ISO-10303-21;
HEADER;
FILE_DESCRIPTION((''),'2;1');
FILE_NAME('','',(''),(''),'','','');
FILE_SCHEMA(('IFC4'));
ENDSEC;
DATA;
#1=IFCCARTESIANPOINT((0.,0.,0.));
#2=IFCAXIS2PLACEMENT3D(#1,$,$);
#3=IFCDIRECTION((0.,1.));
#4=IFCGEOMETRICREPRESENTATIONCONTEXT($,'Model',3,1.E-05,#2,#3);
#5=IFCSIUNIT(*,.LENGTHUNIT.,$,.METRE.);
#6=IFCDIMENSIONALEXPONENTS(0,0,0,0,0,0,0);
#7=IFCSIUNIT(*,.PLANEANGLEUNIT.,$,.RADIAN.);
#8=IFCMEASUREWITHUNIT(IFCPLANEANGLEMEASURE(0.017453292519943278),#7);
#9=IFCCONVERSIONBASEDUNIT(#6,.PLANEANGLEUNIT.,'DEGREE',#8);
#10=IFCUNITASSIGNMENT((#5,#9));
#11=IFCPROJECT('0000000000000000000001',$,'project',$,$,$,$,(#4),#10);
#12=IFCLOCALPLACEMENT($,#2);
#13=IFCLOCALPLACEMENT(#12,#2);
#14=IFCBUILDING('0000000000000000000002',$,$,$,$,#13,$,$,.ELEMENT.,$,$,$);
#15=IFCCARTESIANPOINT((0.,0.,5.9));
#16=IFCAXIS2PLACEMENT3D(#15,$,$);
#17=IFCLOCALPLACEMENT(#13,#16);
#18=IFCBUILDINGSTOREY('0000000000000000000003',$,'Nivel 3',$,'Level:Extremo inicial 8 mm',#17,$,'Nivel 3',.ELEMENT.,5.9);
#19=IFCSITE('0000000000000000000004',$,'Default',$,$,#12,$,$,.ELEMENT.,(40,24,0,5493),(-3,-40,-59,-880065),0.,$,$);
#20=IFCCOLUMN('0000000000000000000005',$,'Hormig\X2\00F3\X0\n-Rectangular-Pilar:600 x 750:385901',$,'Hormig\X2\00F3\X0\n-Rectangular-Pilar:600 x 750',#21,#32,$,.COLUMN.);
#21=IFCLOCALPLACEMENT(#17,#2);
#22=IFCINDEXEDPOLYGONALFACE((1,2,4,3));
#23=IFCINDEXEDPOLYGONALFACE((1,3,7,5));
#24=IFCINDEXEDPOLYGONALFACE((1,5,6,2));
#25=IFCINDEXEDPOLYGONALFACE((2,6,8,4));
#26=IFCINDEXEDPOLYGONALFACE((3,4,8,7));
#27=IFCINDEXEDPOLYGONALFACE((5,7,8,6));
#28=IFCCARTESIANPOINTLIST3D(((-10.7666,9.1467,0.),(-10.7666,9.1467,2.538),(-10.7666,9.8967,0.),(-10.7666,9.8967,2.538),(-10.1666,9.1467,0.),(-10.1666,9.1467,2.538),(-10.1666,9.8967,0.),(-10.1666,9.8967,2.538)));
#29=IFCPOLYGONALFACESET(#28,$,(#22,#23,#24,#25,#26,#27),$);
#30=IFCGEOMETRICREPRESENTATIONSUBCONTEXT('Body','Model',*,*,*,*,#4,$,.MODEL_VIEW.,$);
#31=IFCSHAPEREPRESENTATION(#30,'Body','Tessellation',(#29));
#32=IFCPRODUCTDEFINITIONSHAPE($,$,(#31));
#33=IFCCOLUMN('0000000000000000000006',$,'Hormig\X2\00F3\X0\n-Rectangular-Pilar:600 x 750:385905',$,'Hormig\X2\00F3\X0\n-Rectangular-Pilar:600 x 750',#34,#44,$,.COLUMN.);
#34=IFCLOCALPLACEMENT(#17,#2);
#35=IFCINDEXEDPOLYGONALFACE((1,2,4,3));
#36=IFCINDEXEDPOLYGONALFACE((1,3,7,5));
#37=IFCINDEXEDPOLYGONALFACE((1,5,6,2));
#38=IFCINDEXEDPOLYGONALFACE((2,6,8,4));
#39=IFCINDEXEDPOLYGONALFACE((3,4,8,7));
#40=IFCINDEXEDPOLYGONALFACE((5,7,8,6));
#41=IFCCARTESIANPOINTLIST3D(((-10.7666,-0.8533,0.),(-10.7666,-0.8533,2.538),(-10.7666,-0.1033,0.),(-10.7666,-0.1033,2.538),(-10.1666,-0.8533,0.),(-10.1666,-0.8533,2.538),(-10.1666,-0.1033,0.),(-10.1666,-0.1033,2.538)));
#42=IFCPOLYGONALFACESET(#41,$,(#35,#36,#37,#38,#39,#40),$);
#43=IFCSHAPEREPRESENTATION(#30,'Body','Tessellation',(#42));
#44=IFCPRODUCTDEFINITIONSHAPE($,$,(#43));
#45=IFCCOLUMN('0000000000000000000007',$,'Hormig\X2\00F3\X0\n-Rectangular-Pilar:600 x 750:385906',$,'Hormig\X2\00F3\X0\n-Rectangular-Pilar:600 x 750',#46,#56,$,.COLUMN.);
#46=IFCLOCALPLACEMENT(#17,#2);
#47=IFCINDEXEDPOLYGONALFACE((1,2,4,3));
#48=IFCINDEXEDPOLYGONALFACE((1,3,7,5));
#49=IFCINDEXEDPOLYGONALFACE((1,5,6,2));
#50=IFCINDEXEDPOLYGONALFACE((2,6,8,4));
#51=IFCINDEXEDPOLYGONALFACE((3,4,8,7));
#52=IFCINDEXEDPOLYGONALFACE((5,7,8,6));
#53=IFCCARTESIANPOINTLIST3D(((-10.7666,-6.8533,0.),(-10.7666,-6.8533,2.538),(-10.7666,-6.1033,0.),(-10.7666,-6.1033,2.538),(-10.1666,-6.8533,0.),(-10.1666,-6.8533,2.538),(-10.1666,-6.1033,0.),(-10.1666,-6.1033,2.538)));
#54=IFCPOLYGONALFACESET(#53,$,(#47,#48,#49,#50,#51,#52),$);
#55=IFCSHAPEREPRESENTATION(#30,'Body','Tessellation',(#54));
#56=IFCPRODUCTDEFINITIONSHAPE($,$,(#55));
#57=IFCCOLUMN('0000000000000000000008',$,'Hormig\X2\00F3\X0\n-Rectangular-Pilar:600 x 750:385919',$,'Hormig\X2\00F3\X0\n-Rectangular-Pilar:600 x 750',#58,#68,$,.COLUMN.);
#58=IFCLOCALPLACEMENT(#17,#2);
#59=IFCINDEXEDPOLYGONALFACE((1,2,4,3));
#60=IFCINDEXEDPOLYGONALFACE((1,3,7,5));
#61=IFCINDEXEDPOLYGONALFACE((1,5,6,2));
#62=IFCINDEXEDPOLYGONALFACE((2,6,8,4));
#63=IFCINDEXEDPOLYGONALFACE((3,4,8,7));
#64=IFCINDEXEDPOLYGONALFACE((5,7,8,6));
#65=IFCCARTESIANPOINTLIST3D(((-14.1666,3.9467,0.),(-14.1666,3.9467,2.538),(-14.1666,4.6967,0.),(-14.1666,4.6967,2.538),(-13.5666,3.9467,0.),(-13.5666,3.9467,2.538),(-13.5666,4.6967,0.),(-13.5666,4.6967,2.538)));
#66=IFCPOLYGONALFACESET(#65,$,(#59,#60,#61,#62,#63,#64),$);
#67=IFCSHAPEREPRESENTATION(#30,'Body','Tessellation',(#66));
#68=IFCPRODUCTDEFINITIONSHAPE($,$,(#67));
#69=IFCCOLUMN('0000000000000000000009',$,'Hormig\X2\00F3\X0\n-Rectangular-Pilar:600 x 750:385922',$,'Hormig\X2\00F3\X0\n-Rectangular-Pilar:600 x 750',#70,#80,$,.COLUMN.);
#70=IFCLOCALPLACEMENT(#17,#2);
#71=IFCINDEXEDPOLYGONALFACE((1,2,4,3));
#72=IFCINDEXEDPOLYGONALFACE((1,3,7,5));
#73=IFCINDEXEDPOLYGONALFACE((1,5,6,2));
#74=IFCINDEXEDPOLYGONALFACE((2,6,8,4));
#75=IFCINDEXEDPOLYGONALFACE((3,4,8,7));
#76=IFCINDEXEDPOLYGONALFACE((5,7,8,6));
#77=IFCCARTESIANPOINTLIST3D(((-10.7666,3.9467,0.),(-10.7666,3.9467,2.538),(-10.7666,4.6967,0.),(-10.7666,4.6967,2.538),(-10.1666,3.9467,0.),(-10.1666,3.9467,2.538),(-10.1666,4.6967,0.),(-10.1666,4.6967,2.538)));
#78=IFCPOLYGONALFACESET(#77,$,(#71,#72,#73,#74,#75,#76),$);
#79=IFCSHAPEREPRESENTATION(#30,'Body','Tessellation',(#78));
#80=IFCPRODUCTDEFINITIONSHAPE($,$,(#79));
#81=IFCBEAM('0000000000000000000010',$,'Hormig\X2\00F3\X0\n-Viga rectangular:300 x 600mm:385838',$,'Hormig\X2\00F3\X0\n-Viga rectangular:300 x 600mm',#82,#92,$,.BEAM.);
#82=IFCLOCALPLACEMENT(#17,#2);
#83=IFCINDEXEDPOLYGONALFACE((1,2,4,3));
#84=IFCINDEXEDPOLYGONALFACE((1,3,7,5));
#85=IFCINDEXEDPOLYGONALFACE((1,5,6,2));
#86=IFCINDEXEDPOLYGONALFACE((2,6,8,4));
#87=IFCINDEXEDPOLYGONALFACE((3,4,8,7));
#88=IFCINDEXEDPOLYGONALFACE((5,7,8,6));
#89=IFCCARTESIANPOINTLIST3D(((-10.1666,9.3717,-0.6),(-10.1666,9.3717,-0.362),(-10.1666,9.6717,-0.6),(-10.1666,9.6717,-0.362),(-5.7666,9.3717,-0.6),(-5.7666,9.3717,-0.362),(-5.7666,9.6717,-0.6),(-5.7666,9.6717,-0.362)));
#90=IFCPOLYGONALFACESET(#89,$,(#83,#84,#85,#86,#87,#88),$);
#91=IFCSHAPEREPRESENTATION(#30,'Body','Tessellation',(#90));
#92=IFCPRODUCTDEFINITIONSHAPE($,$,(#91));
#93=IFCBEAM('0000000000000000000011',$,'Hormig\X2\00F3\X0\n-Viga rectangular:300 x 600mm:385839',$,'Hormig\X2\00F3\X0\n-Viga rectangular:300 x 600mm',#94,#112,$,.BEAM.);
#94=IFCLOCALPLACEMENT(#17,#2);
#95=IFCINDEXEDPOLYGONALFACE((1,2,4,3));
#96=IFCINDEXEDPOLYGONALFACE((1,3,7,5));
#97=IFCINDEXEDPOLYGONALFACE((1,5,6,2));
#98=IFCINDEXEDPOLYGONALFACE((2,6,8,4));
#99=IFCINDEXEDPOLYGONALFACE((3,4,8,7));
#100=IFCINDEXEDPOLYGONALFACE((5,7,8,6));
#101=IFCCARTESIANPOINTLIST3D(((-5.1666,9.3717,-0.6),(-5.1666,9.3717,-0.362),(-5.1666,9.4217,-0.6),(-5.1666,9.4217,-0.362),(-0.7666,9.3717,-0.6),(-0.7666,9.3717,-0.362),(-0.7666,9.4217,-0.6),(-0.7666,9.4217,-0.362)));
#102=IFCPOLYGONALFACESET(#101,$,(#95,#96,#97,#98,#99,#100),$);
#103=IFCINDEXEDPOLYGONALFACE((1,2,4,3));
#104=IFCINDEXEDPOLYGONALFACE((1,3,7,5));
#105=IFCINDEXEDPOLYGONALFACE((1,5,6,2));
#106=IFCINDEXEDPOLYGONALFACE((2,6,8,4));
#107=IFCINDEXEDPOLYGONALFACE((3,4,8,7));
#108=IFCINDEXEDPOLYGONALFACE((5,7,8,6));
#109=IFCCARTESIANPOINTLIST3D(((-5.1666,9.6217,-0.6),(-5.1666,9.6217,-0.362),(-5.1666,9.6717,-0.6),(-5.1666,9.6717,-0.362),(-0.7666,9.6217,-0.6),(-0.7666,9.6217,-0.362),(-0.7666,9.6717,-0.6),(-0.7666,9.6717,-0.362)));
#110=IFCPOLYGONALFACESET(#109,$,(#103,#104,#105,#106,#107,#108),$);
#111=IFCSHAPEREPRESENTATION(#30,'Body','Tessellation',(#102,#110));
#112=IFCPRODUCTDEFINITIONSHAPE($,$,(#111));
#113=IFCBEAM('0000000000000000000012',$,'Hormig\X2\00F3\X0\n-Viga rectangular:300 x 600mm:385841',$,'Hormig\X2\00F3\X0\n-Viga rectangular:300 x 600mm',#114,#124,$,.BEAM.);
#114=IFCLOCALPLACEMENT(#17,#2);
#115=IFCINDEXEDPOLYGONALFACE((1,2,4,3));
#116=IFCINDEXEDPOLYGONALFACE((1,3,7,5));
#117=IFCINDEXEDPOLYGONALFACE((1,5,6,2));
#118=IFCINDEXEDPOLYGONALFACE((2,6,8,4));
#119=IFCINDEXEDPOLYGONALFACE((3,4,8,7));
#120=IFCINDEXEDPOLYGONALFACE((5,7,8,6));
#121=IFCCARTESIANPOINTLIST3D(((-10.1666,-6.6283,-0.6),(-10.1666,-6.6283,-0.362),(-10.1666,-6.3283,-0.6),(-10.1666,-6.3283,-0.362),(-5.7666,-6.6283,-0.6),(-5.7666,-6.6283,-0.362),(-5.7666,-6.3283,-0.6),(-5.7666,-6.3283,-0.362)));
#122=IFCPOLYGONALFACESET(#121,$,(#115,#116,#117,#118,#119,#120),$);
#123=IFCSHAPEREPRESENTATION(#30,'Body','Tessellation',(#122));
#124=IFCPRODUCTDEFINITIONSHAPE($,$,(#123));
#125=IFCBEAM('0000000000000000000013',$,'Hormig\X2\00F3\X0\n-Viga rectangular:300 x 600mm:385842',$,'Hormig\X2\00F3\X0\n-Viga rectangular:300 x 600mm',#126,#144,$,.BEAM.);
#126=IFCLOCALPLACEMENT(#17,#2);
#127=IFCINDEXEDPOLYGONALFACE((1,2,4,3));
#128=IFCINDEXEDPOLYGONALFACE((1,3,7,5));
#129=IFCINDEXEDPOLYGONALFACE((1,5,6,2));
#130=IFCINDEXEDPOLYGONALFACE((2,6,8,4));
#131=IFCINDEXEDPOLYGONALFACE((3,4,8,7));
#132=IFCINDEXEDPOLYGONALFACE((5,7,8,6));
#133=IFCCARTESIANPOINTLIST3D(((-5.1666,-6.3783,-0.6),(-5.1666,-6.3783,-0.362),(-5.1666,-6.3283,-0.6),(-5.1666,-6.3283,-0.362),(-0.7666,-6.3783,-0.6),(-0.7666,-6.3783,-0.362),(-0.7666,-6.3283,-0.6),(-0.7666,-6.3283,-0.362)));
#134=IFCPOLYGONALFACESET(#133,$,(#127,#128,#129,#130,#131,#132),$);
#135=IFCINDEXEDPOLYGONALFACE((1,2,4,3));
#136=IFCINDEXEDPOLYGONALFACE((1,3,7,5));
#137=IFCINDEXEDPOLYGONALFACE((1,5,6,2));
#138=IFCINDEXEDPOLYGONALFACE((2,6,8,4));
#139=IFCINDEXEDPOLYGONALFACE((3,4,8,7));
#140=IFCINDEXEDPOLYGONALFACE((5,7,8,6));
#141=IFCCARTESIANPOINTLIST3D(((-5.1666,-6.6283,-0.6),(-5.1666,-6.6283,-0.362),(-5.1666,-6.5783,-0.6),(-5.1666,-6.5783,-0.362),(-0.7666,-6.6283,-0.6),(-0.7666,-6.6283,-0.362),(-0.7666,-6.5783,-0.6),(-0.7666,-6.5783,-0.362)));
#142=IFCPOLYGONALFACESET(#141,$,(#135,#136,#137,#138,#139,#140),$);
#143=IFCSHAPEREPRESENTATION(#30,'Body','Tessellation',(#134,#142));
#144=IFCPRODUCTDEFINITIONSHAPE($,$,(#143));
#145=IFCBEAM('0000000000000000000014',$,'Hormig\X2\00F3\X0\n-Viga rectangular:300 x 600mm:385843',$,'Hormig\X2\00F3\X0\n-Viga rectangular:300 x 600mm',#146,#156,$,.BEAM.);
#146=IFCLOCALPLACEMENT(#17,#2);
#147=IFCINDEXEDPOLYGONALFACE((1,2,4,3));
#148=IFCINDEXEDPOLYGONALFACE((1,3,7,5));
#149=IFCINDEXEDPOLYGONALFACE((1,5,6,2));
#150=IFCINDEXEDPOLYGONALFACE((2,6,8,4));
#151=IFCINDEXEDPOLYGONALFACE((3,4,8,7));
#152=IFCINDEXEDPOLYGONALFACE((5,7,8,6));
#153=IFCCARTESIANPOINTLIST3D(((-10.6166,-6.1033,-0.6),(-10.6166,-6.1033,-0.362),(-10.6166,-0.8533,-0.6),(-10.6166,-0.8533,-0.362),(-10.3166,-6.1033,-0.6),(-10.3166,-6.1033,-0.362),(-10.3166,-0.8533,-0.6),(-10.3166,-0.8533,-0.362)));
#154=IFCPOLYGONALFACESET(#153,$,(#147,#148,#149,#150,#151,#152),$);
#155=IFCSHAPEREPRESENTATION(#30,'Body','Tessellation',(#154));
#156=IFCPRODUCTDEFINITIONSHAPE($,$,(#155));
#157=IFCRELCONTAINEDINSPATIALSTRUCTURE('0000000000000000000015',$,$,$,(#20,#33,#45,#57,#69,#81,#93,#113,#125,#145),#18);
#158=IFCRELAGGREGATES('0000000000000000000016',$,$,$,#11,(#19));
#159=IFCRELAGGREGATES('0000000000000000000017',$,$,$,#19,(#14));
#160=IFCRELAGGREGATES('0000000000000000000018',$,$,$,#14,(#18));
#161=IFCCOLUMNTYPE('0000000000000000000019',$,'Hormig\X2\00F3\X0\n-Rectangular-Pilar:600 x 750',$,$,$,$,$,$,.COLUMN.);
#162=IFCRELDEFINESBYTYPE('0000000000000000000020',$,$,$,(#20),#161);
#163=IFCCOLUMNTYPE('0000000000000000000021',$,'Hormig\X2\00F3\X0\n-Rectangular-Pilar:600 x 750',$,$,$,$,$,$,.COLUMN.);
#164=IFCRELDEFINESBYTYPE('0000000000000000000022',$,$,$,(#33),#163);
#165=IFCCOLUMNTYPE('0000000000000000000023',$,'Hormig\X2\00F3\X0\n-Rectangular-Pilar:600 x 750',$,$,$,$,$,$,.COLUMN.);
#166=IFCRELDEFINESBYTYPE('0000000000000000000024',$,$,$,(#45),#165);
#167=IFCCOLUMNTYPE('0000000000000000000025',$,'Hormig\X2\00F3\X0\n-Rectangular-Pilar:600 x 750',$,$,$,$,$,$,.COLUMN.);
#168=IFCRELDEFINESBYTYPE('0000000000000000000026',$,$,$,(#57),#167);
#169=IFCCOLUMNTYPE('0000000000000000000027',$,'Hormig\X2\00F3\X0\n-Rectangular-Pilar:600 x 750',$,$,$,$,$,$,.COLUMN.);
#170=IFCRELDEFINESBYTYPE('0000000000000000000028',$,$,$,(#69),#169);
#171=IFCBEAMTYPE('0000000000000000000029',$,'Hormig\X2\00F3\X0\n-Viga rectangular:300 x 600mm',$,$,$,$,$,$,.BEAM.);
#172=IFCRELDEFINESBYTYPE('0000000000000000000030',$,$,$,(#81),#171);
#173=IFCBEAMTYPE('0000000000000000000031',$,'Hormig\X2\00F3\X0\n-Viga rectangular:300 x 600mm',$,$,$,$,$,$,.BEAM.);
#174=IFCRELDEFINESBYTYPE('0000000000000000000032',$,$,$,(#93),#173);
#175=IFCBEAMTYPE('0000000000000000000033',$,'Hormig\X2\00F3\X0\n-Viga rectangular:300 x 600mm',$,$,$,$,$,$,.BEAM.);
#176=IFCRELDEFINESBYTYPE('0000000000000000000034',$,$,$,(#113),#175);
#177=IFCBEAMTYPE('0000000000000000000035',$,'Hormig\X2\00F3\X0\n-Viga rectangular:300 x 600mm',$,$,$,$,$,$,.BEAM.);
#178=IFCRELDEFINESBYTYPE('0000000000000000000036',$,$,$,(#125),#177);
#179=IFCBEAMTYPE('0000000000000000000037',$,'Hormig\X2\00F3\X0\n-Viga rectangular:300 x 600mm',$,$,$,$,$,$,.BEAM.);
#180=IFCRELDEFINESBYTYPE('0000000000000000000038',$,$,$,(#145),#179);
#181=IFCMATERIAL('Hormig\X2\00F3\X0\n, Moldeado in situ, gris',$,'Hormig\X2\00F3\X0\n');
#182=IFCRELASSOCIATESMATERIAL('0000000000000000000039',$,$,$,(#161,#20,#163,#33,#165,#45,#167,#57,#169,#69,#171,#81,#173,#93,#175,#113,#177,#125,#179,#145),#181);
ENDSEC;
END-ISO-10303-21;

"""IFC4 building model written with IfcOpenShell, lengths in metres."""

from ifc_helpers import new_model, entity, si_unit, converted_unit, direction, frame, origin, place, context, subcontext, project, spatial, indexed_curve, outline, extrude, source, transform, mapped, material, type_object, type_shapes, element, save


model = new_model("IFC4")

# Units and contexts
model_context = context("Model", 3, precision=1e-05, world=origin(), true_north=direction((0.0, 1.0)))
body_context = subcontext(model_context, "Body", "Model", "MODEL_VIEW")
ifc_project = project(units=[si_unit("LENGTHUNIT", "METRE"), converted_unit("PLANEANGLEUNIT", "DEGREE", entity("IfcPlaneAngleMeasure", 0.017453292519943278), si_unit("PLANEANGLEUNIT", "RADIAN"), dimensions=[0, 0, 0, 0, 0, 0, 0])], contexts=[model_context])

# Site, building, storey
site_placement = place(None, origin())
site = spatial("IfcSite", under=ifc_project, at=site_placement, Name="Default", CompositionType="ELEMENT", RefLatitude=(40, 24, 0, 5493), RefLongitude=(-3, -40, -59, -880065), RefElevation=0.0)
building_placement = place(site_placement, origin())
building = spatial("IfcBuilding", under=site, at=building_placement, CompositionType="ELEMENT")
storey_placement = place(building_placement, frame((0.0, 0.0, 5.9)))
storey = spatial("IfcBuildingStorey", under=building, at=storey_placement, Name="Nivel 3", ObjectType="Level:Extremo inicial 8 mm", LongName="Nivel 3", CompositionType="ELEMENT", Elevation=5.9)

# Columns
ifc_material_1 = material(Name="Hormigón, Moldeado in situ, gris", Category="Hormigón")
column_type_1 = type_object("IfcColumnType", Name="Hormigón-Rectangular-Pilar:600 x 750", PredefinedType="COLUMN", material=ifc_material_1)
shared_shape_1 = source(origin(), body_context, "Body", "SweptSolid", [
    extrude(outline(indexed_curve([(-0.3, -0.375), (0.3, -0.375), (0.3, 0.375), (-0.3, 0.375), (-0.3, -0.375)], self_intersect=False)), frame((-10.4666, 9.5217, 5.9), z_axis=(0.0, 0.0, 1.0), x_axis=(-1.0, 0.0, 0.0)), (0.0, 0.0, 1.0), 2.538),
])
type_shapes(column_type_1, [shared_shape_1])
column_1_placement = place(storey_placement, frame((0.0, 0.0, -5.9)))
element("IfcColumn", 1, at=column_1_placement, inside=storey, type_object=column_type_1, material=ifc_material_1, Name="Hormigón-Rectangular-Pilar:600 x 750:385901", ObjectType="Hormigón-Rectangular-Pilar:600 x 750", PredefinedType="COLUMN", context=body_context, shape_type="MappedRepresentation", body=[
    mapped(shared_shape_1, transform((0.0, 0.0, 0.0), scale=1.0)),
])
column_type_2 = type_object("IfcColumnType", Name="Hormigón-Rectangular-Pilar:600 x 750", PredefinedType="COLUMN", material=ifc_material_1)
shared_shape_2 = source(origin(), body_context, "Body", "SweptSolid", [
    extrude(outline(indexed_curve([(-0.3, -0.375), (0.3, -0.375), (0.3, 0.375), (-0.3, 0.375), (-0.3, -0.375)], self_intersect=False)), frame((-10.4666, -0.4783, 5.9), z_axis=(0.0, 0.0, 1.0), x_axis=(-1.0, 0.0, 0.0)), (0.0, 0.0, 1.0), 2.538),
])
type_shapes(column_type_2, [shared_shape_2])
column_2_placement = place(storey_placement, frame((0.0, 0.0, -5.9)))
element("IfcColumn", 2, at=column_2_placement, inside=storey, type_object=column_type_2, material=ifc_material_1, Name="Hormigón-Rectangular-Pilar:600 x 750:385905", ObjectType="Hormigón-Rectangular-Pilar:600 x 750", PredefinedType="COLUMN", context=body_context, shape_type="MappedRepresentation", body=[
    mapped(shared_shape_2, transform((0.0, 0.0, 0.0), scale=1.0)),
])
column_type_3 = type_object("IfcColumnType", Name="Hormigón-Rectangular-Pilar:600 x 750", PredefinedType="COLUMN", material=ifc_material_1)
shared_shape_3 = source(origin(), body_context, "Body", "SweptSolid", [
    extrude(outline(indexed_curve([(-0.3, -0.375), (0.3, -0.375), (0.3, 0.375), (-0.3, 0.375), (-0.3, -0.375)], self_intersect=False)), frame((-10.4666, -6.4783, 5.9), z_axis=(0.0, 0.0, 1.0), x_axis=(-1.0, 0.0, 0.0)), (0.0, 0.0, 1.0), 2.538),
])
type_shapes(column_type_3, [shared_shape_3])
column_3_placement = place(storey_placement, frame((0.0, 0.0, -5.9)))
element("IfcColumn", 3, at=column_3_placement, inside=storey, type_object=column_type_3, material=ifc_material_1, Name="Hormigón-Rectangular-Pilar:600 x 750:385906", ObjectType="Hormigón-Rectangular-Pilar:600 x 750", PredefinedType="COLUMN", context=body_context, shape_type="MappedRepresentation", body=[
    mapped(shared_shape_3, transform((0.0, 0.0, 0.0), scale=1.0)),
])
column_type_4 = type_object("IfcColumnType", Name="Hormigón-Rectangular-Pilar:600 x 750", PredefinedType="COLUMN", material=ifc_material_1)
shared_shape_4 = source(origin(), body_context, "Body", "SweptSolid", [
    extrude(outline(indexed_curve([(-0.3, -0.375), (0.3, -0.375), (0.3, 0.375), (-0.3, 0.375), (-0.3, -0.375)], self_intersect=False)), frame((-13.8666, 4.3217, 5.9), z_axis=(0.0, 0.0, 1.0), x_axis=(-1.0, 0.0, 0.0)), (0.0, 0.0, 1.0), 2.538),
])
type_shapes(column_type_4, [shared_shape_4])
column_4_placement = place(storey_placement, frame((0.0, 0.0, -5.9)))
element("IfcColumn", 4, at=column_4_placement, inside=storey, type_object=column_type_4, material=ifc_material_1, Name="Hormigón-Rectangular-Pilar:600 x 750:385919", ObjectType="Hormigón-Rectangular-Pilar:600 x 750", PredefinedType="COLUMN", context=body_context, shape_type="MappedRepresentation", body=[
    mapped(shared_shape_4, transform((0.0, 0.0, 0.0), scale=1.0)),
])
column_type_5 = type_object("IfcColumnType", Name="Hormigón-Rectangular-Pilar:600 x 750", PredefinedType="COLUMN", material=ifc_material_1)
shared_shape_5 = source(origin(), body_context, "Body", "SweptSolid", [
    extrude(outline(indexed_curve([(-0.3, -0.375), (0.3, -0.375), (0.3, 0.375), (-0.3, 0.375), (-0.3, -0.375)], self_intersect=False)), frame((-10.4666, 4.3217, 5.9), z_axis=(0.0, 0.0, 1.0), x_axis=(-1.0, 0.0, 0.0)), (0.0, 0.0, 1.0), 2.538),
])
type_shapes(column_type_5, [shared_shape_5])
column_5_placement = place(storey_placement, frame((0.0, 0.0, -5.9)))
element("IfcColumn", 5, at=column_5_placement, inside=storey, type_object=column_type_5, material=ifc_material_1, Name="Hormigón-Rectangular-Pilar:600 x 750:385922", ObjectType="Hormigón-Rectangular-Pilar:600 x 750", PredefinedType="COLUMN", context=body_context, shape_type="MappedRepresentation", body=[
    mapped(shared_shape_5, transform((0.0, 0.0, 0.0), scale=1.0)),
])

# Beams
beam_type_1 = type_object("IfcBeamType", Name="Hormigón-Viga rectangular:300 x 600mm", PredefinedType="BEAM", material=ifc_material_1)
shared_shape_6 = source(origin(), body_context, "Body", "SweptSolid", [
    extrude(outline(indexed_curve([(-0.119, -0.15), (0.119, -0.15), (0.119, 0.15), (-0.119, 0.15), (-0.119, -0.15)], self_intersect=False)), frame((-5.7666, 9.5217, 5.419), z_axis=(-1.0, 0.0, 0.0), x_axis=(0.0, 0.0, -1.0)), (0.0, 0.0, 1.0), 4.4),
])
type_shapes(beam_type_1, [shared_shape_6])
beam_1_placement = place(storey_placement, frame((0.0, 0.0, -5.9)))
element("IfcBeam", 6, at=beam_1_placement, inside=storey, type_object=beam_type_1, material=ifc_material_1, Name="Hormigón-Viga rectangular:300 x 600mm:385838", ObjectType="Hormigón-Viga rectangular:300 x 600mm", PredefinedType="BEAM", context=body_context, shape_type="MappedRepresentation", body=[
    mapped(shared_shape_6, transform((0.0, 0.0, 0.0), scale=1.0)),
])
beam_type_2 = type_object("IfcBeamType", Name="Hormigón-Viga rectangular:300 x 600mm", PredefinedType="BEAM", material=ifc_material_1)
shared_shape_7 = source(origin(), body_context, "Body", "SweptSolid", [
    extrude(outline(indexed_curve([(-0.119, -0.025), (0.119, -0.025), (0.119, 0.025), (-0.119, 0.025), (-0.119, -0.025)], self_intersect=False)), frame((-5.1666, 9.3967, 5.419), z_axis=(1.0, 0.0, 0.0), x_axis=(0.0, 0.0, -1.0)), (0.0, 0.0, 1.0), 4.4),
    extrude(outline(indexed_curve([(-0.119, -0.025), (0.119, -0.025), (0.119, 0.025), (-0.119, 0.025), (-0.119, -0.025)], self_intersect=False)), frame((-5.1666, 9.6467, 5.419), z_axis=(1.0, 0.0, 0.0), x_axis=(0.0, 0.0, -1.0)), (0.0, 0.0, 1.0), 4.4),
])
type_shapes(beam_type_2, [shared_shape_7])
beam_2_placement = place(storey_placement, frame((0.0, 0.0, -5.9)))
element("IfcBeam", 7, at=beam_2_placement, inside=storey, type_object=beam_type_2, material=ifc_material_1, Name="Hormigón-Viga rectangular:300 x 600mm:385839", ObjectType="Hormigón-Viga rectangular:300 x 600mm", PredefinedType="BEAM", context=body_context, shape_type="MappedRepresentation", body=[
    mapped(shared_shape_7, transform((0.0, 0.0, 0.0), scale=1.0)),
])
beam_type_3 = type_object("IfcBeamType", Name="Hormigón-Viga rectangular:300 x 600mm", PredefinedType="BEAM", material=ifc_material_1)
shared_shape_8 = source(origin(), body_context, "Body", "SweptSolid", [
    extrude(outline(indexed_curve([(-0.119, -0.15), (0.119, -0.15), (0.119, 0.15), (-0.119, 0.15), (-0.119, -0.15)], self_intersect=False)), frame((-10.1666, -6.4783, 5.419), z_axis=(1.0, 0.0, 0.0), x_axis=(0.0, 0.0, -1.0)), (0.0, 0.0, 1.0), 4.4),
])
type_shapes(beam_type_3, [shared_shape_8])
beam_3_placement = place(storey_placement, frame((0.0, 0.0, -5.9)))
element("IfcBeam", 8, at=beam_3_placement, inside=storey, type_object=beam_type_3, material=ifc_material_1, Name="Hormigón-Viga rectangular:300 x 600mm:385841", ObjectType="Hormigón-Viga rectangular:300 x 600mm", PredefinedType="BEAM", context=body_context, shape_type="MappedRepresentation", body=[
    mapped(shared_shape_8, transform((0.0, 0.0, 0.0), scale=1.0)),
])
beam_type_4 = type_object("IfcBeamType", Name="Hormigón-Viga rectangular:300 x 600mm", PredefinedType="BEAM", material=ifc_material_1)
shared_shape_9 = source(origin(), body_context, "Body", "SweptSolid", [
    extrude(outline(indexed_curve([(-0.119, -0.025), (0.119, -0.025), (0.119, 0.025), (-0.119, 0.025), (-0.119, -0.025)], self_intersect=False)), frame((-0.7666, -6.3533, 5.419), z_axis=(-1.0, 0.0, 0.0), x_axis=(0.0, 0.0, -1.0)), (0.0, 0.0, 1.0), 4.4),
    extrude(outline(indexed_curve([(-0.119, -0.025), (0.119, -0.025), (0.119, 0.025), (-0.119, 0.025), (-0.119, -0.025)], self_intersect=False)), frame((-0.7666, -6.6033, 5.419), z_axis=(-1.0, 0.0, 0.0), x_axis=(0.0, 0.0, -1.0)), (0.0, 0.0, 1.0), 4.4),
])
type_shapes(beam_type_4, [shared_shape_9])
beam_4_placement = place(storey_placement, frame((0.0, 0.0, -5.9)))
element("IfcBeam", 9, at=beam_4_placement, inside=storey, type_object=beam_type_4, material=ifc_material_1, Name="Hormigón-Viga rectangular:300 x 600mm:385842", ObjectType="Hormigón-Viga rectangular:300 x 600mm", PredefinedType="BEAM", context=body_context, shape_type="MappedRepresentation", body=[
    mapped(shared_shape_9, transform((0.0, 0.0, 0.0), scale=1.0)),
])
beam_type_5 = type_object("IfcBeamType", Name="Hormigón-Viga rectangular:300 x 600mm", PredefinedType="BEAM", material=ifc_material_1)
shared_shape_10 = source(origin(), body_context, "Body", "SweptSolid", [
    extrude(outline(indexed_curve([(-0.15, -0.119), (0.15, -0.119), (0.15, 0.119), (-0.15, 0.119), (-0.15, -0.119)], self_intersect=False)), frame((-10.4666, -6.1033, 5.419), z_axis=(0.0, 1.0, 0.0), x_axis=(-1.0, 0.0, 0.0)), (0.0, 0.0, 1.0), 5.25),
])
type_shapes(beam_type_5, [shared_shape_10])
beam_5_placement = place(storey_placement, frame((0.0, 0.0, -5.9)))
element("IfcBeam", 10, at=beam_5_placement, inside=storey, type_object=beam_type_5, material=ifc_material_1, Name="Hormigón-Viga rectangular:300 x 600mm:385843", ObjectType="Hormigón-Viga rectangular:300 x 600mm", PredefinedType="BEAM", context=body_context, shape_type="MappedRepresentation", body=[
    mapped(shared_shape_10, transform((0.0, 0.0, 0.0), scale=1.0)),
])

save(model, "model.ifc")
